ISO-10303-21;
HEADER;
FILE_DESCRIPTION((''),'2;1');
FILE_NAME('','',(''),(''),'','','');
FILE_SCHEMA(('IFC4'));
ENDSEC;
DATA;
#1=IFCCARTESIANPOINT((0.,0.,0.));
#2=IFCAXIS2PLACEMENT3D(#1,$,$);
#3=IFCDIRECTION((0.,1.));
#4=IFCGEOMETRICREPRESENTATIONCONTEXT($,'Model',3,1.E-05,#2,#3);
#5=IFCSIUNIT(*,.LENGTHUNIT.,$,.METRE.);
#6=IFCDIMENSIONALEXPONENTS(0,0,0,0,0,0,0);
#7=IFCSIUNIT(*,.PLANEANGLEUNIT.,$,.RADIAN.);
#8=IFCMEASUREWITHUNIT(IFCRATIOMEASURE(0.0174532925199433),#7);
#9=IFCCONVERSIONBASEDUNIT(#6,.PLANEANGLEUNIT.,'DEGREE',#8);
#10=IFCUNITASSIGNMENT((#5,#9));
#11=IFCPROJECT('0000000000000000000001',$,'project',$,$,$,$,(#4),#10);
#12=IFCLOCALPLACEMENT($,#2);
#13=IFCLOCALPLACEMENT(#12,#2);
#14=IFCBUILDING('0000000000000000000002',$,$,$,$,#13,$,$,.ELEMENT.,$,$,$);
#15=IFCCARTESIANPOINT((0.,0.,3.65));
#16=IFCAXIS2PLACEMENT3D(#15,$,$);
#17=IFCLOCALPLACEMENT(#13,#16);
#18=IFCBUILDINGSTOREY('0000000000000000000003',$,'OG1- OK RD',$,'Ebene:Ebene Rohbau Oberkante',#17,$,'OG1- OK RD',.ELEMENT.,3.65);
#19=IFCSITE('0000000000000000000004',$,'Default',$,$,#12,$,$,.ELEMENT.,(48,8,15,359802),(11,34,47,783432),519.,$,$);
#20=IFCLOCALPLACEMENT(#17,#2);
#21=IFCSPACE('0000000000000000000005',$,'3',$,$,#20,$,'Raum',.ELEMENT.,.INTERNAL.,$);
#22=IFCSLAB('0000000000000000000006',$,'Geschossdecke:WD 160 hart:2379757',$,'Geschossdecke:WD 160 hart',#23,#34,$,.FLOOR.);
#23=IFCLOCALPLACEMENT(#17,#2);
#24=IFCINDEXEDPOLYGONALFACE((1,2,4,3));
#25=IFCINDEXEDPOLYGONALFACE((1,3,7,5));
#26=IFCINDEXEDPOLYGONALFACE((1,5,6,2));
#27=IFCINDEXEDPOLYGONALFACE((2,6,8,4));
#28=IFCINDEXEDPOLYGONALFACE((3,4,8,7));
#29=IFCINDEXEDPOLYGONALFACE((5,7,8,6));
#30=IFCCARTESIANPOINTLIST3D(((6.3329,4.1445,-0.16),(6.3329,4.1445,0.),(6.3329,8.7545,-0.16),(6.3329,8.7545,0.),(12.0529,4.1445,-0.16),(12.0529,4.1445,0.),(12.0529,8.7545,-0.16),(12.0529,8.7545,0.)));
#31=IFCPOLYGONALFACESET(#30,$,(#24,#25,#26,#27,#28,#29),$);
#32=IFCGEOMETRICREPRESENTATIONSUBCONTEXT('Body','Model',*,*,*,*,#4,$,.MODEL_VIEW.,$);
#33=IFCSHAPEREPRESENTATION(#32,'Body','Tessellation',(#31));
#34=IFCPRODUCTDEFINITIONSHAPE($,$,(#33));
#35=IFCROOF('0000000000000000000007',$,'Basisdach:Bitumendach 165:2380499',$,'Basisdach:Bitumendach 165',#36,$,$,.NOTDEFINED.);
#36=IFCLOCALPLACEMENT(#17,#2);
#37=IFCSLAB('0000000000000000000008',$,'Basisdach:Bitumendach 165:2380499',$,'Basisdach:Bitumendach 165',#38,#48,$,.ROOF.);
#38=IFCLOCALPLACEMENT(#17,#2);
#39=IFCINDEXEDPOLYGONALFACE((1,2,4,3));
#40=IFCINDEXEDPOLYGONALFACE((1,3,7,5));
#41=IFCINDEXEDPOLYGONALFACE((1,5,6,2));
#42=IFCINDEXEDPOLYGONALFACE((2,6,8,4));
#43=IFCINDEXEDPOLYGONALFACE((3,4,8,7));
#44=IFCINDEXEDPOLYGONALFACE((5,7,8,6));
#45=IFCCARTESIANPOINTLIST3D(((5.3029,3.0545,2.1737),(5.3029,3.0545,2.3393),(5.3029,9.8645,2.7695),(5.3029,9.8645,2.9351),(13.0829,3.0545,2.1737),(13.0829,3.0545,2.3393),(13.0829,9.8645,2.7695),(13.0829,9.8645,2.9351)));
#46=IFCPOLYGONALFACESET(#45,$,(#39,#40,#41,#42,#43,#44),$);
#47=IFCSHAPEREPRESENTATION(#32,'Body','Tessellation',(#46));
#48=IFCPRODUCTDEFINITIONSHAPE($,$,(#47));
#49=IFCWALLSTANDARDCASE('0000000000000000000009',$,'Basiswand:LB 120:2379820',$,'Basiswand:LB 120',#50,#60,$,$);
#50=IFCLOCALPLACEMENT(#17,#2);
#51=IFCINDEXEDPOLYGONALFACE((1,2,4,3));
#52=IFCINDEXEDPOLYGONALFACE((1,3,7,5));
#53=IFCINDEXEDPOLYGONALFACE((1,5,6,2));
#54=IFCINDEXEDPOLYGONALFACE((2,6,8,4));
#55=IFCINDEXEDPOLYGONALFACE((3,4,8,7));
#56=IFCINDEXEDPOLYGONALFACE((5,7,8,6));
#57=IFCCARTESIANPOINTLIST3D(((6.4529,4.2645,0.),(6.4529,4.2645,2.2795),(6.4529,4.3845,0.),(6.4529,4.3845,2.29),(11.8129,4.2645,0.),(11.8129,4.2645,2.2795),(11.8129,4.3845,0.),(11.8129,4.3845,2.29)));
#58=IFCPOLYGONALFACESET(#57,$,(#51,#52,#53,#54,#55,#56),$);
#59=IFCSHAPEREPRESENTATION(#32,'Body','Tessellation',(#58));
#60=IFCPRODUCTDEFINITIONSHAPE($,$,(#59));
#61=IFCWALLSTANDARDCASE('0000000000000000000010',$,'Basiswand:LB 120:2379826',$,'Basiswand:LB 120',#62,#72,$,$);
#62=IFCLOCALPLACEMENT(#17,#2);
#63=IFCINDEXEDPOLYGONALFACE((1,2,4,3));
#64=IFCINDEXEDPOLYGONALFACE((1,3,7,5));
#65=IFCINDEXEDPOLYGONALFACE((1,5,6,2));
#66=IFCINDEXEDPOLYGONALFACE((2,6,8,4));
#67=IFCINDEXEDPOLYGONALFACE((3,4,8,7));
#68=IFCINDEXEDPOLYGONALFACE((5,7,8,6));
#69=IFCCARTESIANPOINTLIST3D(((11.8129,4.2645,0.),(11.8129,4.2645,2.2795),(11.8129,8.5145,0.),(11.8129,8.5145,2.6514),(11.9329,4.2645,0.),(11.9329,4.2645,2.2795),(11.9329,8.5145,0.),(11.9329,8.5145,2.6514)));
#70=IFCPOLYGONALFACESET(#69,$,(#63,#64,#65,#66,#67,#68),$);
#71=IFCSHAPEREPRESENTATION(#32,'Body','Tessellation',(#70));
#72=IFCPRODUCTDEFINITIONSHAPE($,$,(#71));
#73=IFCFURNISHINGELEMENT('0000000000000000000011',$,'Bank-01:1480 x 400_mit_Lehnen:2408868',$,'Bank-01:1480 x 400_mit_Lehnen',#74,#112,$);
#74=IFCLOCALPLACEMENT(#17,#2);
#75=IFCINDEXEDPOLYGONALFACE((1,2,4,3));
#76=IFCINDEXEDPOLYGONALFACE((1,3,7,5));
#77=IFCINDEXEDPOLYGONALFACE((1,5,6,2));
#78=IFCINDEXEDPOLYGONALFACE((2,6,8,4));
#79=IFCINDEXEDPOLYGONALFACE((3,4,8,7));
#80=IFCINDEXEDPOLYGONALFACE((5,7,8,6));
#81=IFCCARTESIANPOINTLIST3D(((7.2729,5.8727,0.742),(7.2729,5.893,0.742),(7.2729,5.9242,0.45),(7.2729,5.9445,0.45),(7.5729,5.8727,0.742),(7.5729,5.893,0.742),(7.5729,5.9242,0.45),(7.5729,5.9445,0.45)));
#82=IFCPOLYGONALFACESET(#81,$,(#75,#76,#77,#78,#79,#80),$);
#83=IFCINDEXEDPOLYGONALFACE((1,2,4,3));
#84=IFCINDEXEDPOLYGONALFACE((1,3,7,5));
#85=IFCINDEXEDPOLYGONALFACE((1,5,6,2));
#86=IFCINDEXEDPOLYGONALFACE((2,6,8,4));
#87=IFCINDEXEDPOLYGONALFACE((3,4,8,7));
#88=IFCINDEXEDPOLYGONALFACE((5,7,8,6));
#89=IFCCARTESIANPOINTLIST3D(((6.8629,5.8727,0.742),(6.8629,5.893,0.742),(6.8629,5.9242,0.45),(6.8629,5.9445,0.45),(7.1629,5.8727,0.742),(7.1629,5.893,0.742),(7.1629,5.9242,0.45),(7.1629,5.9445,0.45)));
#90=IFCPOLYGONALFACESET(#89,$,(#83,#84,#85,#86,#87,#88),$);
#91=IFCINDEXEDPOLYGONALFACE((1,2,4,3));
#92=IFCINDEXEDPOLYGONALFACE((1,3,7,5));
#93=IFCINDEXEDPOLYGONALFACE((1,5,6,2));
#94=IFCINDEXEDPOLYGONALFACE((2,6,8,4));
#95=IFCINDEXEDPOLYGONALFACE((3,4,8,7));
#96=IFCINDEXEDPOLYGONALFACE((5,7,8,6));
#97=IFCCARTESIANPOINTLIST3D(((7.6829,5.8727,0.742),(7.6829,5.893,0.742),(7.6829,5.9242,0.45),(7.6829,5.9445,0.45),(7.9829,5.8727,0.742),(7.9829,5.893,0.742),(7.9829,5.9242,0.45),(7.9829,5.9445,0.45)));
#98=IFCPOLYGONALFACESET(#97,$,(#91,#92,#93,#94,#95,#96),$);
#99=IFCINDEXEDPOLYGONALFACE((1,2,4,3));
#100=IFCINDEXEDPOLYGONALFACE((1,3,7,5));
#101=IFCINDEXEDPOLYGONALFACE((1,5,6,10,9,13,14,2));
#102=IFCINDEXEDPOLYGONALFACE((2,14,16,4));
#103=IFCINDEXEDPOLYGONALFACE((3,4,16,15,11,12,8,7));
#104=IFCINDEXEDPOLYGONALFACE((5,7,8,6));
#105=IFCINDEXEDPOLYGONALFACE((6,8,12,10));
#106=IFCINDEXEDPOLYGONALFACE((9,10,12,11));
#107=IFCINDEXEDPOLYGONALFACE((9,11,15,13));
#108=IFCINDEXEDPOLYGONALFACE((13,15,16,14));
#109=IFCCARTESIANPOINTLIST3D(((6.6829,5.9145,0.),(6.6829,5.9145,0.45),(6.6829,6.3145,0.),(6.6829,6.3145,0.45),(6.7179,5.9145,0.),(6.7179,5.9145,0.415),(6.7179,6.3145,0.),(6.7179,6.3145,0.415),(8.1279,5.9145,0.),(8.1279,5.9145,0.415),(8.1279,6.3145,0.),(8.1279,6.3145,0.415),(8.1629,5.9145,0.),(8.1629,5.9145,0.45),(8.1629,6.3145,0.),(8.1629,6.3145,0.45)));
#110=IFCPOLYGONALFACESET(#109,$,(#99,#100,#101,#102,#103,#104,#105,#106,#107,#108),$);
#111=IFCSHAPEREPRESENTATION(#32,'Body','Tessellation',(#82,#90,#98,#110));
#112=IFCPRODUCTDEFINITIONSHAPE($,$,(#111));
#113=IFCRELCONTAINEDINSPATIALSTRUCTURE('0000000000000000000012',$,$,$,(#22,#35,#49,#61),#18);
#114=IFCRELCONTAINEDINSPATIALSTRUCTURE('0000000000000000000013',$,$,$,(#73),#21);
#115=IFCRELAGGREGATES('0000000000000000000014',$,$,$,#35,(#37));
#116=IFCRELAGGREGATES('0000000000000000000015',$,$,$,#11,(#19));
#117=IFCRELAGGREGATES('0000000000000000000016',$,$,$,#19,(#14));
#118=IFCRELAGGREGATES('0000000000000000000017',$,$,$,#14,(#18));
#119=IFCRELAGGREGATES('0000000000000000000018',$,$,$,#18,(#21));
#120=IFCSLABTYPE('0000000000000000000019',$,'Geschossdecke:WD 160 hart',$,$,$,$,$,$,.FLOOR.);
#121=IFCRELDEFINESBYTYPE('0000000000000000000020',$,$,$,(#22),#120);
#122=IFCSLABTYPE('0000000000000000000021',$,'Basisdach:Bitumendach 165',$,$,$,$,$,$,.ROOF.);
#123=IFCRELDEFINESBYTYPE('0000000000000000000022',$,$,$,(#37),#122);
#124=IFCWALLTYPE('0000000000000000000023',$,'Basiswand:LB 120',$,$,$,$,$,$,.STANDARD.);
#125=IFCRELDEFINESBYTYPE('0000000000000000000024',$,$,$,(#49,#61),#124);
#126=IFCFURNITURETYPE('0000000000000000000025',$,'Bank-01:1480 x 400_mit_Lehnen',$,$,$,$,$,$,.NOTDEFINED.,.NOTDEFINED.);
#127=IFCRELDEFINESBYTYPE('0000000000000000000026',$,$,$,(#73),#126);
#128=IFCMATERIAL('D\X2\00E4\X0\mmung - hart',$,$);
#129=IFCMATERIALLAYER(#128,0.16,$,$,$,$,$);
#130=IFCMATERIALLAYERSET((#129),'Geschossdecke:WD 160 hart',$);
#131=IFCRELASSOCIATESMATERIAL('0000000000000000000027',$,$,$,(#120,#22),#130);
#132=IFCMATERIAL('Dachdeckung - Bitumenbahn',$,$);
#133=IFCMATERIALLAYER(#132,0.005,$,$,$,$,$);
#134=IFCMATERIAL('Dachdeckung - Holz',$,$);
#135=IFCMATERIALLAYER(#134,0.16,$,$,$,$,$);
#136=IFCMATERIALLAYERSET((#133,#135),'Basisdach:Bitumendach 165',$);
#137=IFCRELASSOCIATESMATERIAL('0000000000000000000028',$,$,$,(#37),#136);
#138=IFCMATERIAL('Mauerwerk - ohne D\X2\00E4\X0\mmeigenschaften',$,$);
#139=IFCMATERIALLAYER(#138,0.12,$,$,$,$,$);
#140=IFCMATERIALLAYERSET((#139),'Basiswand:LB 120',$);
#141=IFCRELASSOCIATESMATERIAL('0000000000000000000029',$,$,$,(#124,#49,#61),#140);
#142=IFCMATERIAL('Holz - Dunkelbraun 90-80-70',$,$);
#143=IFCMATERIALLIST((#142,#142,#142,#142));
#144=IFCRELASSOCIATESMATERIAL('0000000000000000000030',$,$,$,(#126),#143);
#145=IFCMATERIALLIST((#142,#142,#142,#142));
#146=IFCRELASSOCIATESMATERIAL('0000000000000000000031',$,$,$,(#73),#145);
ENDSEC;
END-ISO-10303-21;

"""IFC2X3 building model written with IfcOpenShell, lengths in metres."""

from ifc_helpers import new_model, entity, si_unit, converted_unit, direction, frame, frame_2d, origin, place, context, subcontext, project, spatial, polyline, rectangle, outline, extrude, clip, bounded_halfspace, source, transform, mapped, material, material_list, layer, layer_set, layer_usage, type_object, type_shapes, element, aggregate, save


model = new_model("IFC2X3")

# Units and contexts
model_context = context("Model", 3, precision=1e-05, world=origin(), true_north=direction((0.0, 1.0)))
body_context = subcontext(model_context, "Body", "Model", "MODEL_VIEW")
ifc_project = project(units=[si_unit("LENGTHUNIT", "METRE"), converted_unit("PLANEANGLEUNIT", "DEGREE", entity("IfcRatioMeasure", 0.0174532925199433), si_unit("PLANEANGLEUNIT", "RADIAN"), dimensions=[0, 0, 0, 0, 0, 0, 0])], contexts=[model_context])

# Site, building, storey
site_placement = place(None, origin())
site = spatial("IfcSite", under=ifc_project, at=site_placement, Name="Default", CompositionType="ELEMENT", RefLatitude=(48, 8, 15, 359802), RefLongitude=(11, 34, 47, 783432), RefElevation=519.0)
building_placement = place(site_placement, origin())
building = spatial("IfcBuilding", under=site, at=building_placement, CompositionType="ELEMENT")
storey_placement = place(building_placement, frame((0.0, 0.0, 3.65)))
storey = spatial("IfcBuildingStorey", under=building, at=storey_placement, Name="OG1- OK RD", ObjectType="Ebene:Ebene Rohbau Oberkante", LongName="OG1- OK RD", CompositionType="ELEMENT", Elevation=3.65)

# Slab
ifc_material_1 = material(Name="Dämmung - hart")
ifc_layer_1 = layer(ifc_material_1, 0.16)
ifc_layer_set_1 = layer_set([ifc_layer_1], Name="Geschossdecke:WD 160 hart")
ifc_layer_usage_1 = layer_usage(ifc_layer_set_1, "AXIS3", "POSITIVE", 0.0)
slab_type_1 = type_object("IfcSlabType", Name="Geschossdecke:WD 160 hart", PredefinedType="FLOOR", material=ifc_layer_set_1)
slab_1_placement = place(storey_placement, origin())
element("IfcSlab", 1, at=slab_1_placement, inside=storey, type_object=slab_type_1, material=ifc_layer_usage_1, Name="Geschossdecke:WD 160 hart:2379757", ObjectType="Geschossdecke:WD 160 hart", PredefinedType="FLOOR", context=body_context, shape_type="SweptSolid", body=[
    extrude(rectangle(XDim=4.61, YDim=5.72, at=frame_2d((0.0, 0.0), x_axis=(1.0, 0.0))), frame((9.1929, 6.4495, 0.0), z_axis=(0.0, 0.0, -1.0), x_axis=(0.0, 1.0, 0.0)), (0.0, 0.0, 1.0), 0.16),
])

# Roof, slab
roof_placement = place(storey_placement, frame((5.3029, 3.0545, 2.1737)))
roof = element("IfcRoof", 2, at=roof_placement, inside=storey, Name="Basisdach:Bitumendach 165:2380499", ObjectType="Basisdach:Bitumendach 165", ShapeType="NOTDEFINED")
ifc_material_2 = material(Name="Dachdeckung - Bitumenbahn")
ifc_layer_2 = layer(ifc_material_2, 0.005)
ifc_material_3 = material(Name="Dachdeckung - Holz")
ifc_layer_3 = layer(ifc_material_3, 0.16)
ifc_layer_set_2 = layer_set([ifc_layer_2, ifc_layer_3], Name="Basisdach:Bitumendach 165")
slab_type_2 = type_object("IfcSlabType", Name="Basisdach:Bitumendach 165", PredefinedType="ROOF")
slab_2_placement = place(roof_placement, origin())
slab_2 = element("IfcSlab", 3, at=slab_2_placement, type_object=slab_type_2, material=ifc_layer_set_2, Name="Basisdach:Bitumendach 165:2380499", ObjectType="Basisdach:Bitumendach 165", PredefinedType="ROOF", context=body_context, shape_type="SweptSolid", body=[
    extrude(rectangle(XDim=6.836, YDim=7.78, at=frame_2d((0.0, 0.0), x_axis=(0.0, -1.0))), frame((3.89, 3.405, 0.2979), z_axis=(0.0, -0.087156, 0.996195), x_axis=(1.0, 0.0, 0.0)), (0.0, 0.087156, 0.996195), 0.1656),
])
aggregate(roof, [slab_2])

# Walls
ifc_material_4 = material(Name="Mauerwerk - ohne Dämmeigenschaften")
ifc_layer_4 = layer(ifc_material_4, 0.12)
ifc_layer_set_3 = layer_set([ifc_layer_4], Name="Basiswand:LB 120")
ifc_layer_usage_2 = layer_usage(ifc_layer_set_3, "AXIS2", "NEGATIVE", 0.06)
wall_type = type_object("IfcWallType", Name="Basiswand:LB 120", PredefinedType="STANDARD", material=ifc_layer_set_3)
wall_1_placement = place(storey_placement, frame((6.4529, 4.3245, 0.0)))
element("IfcWallStandardCase", 4, at=wall_1_placement, inside=storey, type_object=wall_type, material=ifc_layer_usage_2, Name="Basiswand:LB 120:2379820", ObjectType="Basiswand:LB 120", context=body_context, shape_type="Clipping", body=[
    clip(extrude(rectangle(XDim=5.36, YDim=0.12, at=frame_2d((2.68, 0.0), x_axis=(-1.0, 0.0))), origin(), (0.0, 0.0, 1.0), 2.29), bounded_halfspace(frame((0.0, -0.06, 2.2795), z_axis=(0.0, -0.087156, 0.996195), x_axis=(1.0, 0.0, 0.0)), False, frame((0.0, -0.06, 2.2795)), polyline([(0.0, 0.0), (5.36, 0.0), (5.36, 0.12), (0.12, 0.12), (0.0, 0.12), (0.0, 0.0)]))),
])
ifc_layer_usage_3 = layer_usage(ifc_layer_set_3, "AXIS2", "NEGATIVE", 0.06)
wall_2_placement = place(storey_placement, frame((11.8729, 4.2645, 0.0), z_axis=(0.0, 0.0, 1.0), x_axis=(0.0, 1.0, 0.0)))
element("IfcWallStandardCase", 5, at=wall_2_placement, inside=storey, type_object=wall_type, material=ifc_layer_usage_3, Name="Basiswand:LB 120:2379826", ObjectType="Basiswand:LB 120", context=body_context, shape_type="Clipping", body=[
    clip(extrude(rectangle(XDim=4.25, YDim=0.12, at=frame_2d((2.125, 0.0), x_axis=(-1.0, 0.0))), origin(), (0.0, 0.0, 1.0), 2.6514), bounded_halfspace(frame((0.0, -0.06, 2.2795), z_axis=(-0.087156, 0.0, 0.996195), x_axis=(0.0, -1.0, 0.0)), False, frame((0.0, -0.06, 2.2795)), polyline([(0.0, 0.0), (4.25, 0.0), (4.25, 0.12), (0.12, 0.12), (0.0, 0.12), (0.0, 0.0)]))),
])

# Shared definitions
space_placement = place(storey_placement, origin())
space = spatial("IfcSpace", under=storey, at=space_placement, Name="3", LongName="Raum", CompositionType="ELEMENT", InteriorOrExteriorSpace="INTERNAL")

# Furnishing element
ifc_material_5 = material(Name="Holz - Dunkelbraun 90-80-70")
ifc_material_list_1 = material_list([ifc_material_5, ifc_material_5, ifc_material_5, ifc_material_5])
ifc_material_list_2 = material_list([ifc_material_5, ifc_material_5, ifc_material_5, ifc_material_5])
furniture_type_1 = type_object("IfcFurnitureType", Name="Bank-01:1480 x 400_mit_Lehnen", material=ifc_material_list_2)
shared_shape_1 = source(origin(), body_context, "Body", "SweptSolid", [
    extrude(outline(polyline([(0.0156, -0.146), (0.0359, -0.146), (-0.0156, 0.146), (-0.0359, 0.146), (0.0156, -0.146)])), frame((-0.3053, -0.3866, 0.596), z_axis=(1.0, 0.0, 0.0), x_axis=(0.0, -1.0, 0.0)), (0.0, 0.0, 1.0), 0.3),
    extrude(outline(polyline([(0.0156, -0.146), (0.0359, -0.146), (-0.0156, 0.146), (-0.0359, 0.146), (0.0156, -0.146)])), frame((-0.7153, -0.3866, 0.596), z_axis=(1.0, 0.0, 0.0), x_axis=(0.0, -1.0, 0.0)), (0.0, 0.0, 1.0), 0.3),
    extrude(outline(polyline([(0.0156, -0.146), (0.0359, -0.146), (-0.0156, 0.146), (-0.0359, 0.146), (0.0156, -0.146)])), frame((0.1047, -0.3866, 0.596), z_axis=(1.0, 0.0, 0.0), x_axis=(0.0, -1.0, 0.0)), (0.0, 0.0, 1.0), 0.3),
    extrude(outline(polyline([(-0.74, -0.2337), (0.74, -0.2337), (0.74, 0.2163), (0.705, 0.2163), (0.705, -0.1988), (-0.705, -0.1988), (-0.705, 0.2163), (-0.74, 0.2163), (-0.74, -0.2337)])), frame((-0.1553, -0.3807, 0.2163), z_axis=(0.0, 1.0, 0.0), x_axis=(1.0, 0.0, 0.0)), (0.0, 0.0, 1.0), 0.4),
])
type_shapes(furniture_type_1, [shared_shape_1])
furnishing_1_placement = place(space_placement, frame((7.5782, 6.2952, 0.0)))
element("IfcFurnishingElement", 6, at=furnishing_1_placement, inside=space, type_object=furniture_type_1, material=ifc_material_list_1, Name="Bank-01:1480 x 400_mit_Lehnen:2408868", ObjectType="Bank-01:1480 x 400_mit_Lehnen", context=body_context, shape_type="MappedRepresentation", body=[
    mapped(shared_shape_1, transform((0.0, 0.0, 0.0), scale=1.0)),
])

save(model, "model.ifc")
